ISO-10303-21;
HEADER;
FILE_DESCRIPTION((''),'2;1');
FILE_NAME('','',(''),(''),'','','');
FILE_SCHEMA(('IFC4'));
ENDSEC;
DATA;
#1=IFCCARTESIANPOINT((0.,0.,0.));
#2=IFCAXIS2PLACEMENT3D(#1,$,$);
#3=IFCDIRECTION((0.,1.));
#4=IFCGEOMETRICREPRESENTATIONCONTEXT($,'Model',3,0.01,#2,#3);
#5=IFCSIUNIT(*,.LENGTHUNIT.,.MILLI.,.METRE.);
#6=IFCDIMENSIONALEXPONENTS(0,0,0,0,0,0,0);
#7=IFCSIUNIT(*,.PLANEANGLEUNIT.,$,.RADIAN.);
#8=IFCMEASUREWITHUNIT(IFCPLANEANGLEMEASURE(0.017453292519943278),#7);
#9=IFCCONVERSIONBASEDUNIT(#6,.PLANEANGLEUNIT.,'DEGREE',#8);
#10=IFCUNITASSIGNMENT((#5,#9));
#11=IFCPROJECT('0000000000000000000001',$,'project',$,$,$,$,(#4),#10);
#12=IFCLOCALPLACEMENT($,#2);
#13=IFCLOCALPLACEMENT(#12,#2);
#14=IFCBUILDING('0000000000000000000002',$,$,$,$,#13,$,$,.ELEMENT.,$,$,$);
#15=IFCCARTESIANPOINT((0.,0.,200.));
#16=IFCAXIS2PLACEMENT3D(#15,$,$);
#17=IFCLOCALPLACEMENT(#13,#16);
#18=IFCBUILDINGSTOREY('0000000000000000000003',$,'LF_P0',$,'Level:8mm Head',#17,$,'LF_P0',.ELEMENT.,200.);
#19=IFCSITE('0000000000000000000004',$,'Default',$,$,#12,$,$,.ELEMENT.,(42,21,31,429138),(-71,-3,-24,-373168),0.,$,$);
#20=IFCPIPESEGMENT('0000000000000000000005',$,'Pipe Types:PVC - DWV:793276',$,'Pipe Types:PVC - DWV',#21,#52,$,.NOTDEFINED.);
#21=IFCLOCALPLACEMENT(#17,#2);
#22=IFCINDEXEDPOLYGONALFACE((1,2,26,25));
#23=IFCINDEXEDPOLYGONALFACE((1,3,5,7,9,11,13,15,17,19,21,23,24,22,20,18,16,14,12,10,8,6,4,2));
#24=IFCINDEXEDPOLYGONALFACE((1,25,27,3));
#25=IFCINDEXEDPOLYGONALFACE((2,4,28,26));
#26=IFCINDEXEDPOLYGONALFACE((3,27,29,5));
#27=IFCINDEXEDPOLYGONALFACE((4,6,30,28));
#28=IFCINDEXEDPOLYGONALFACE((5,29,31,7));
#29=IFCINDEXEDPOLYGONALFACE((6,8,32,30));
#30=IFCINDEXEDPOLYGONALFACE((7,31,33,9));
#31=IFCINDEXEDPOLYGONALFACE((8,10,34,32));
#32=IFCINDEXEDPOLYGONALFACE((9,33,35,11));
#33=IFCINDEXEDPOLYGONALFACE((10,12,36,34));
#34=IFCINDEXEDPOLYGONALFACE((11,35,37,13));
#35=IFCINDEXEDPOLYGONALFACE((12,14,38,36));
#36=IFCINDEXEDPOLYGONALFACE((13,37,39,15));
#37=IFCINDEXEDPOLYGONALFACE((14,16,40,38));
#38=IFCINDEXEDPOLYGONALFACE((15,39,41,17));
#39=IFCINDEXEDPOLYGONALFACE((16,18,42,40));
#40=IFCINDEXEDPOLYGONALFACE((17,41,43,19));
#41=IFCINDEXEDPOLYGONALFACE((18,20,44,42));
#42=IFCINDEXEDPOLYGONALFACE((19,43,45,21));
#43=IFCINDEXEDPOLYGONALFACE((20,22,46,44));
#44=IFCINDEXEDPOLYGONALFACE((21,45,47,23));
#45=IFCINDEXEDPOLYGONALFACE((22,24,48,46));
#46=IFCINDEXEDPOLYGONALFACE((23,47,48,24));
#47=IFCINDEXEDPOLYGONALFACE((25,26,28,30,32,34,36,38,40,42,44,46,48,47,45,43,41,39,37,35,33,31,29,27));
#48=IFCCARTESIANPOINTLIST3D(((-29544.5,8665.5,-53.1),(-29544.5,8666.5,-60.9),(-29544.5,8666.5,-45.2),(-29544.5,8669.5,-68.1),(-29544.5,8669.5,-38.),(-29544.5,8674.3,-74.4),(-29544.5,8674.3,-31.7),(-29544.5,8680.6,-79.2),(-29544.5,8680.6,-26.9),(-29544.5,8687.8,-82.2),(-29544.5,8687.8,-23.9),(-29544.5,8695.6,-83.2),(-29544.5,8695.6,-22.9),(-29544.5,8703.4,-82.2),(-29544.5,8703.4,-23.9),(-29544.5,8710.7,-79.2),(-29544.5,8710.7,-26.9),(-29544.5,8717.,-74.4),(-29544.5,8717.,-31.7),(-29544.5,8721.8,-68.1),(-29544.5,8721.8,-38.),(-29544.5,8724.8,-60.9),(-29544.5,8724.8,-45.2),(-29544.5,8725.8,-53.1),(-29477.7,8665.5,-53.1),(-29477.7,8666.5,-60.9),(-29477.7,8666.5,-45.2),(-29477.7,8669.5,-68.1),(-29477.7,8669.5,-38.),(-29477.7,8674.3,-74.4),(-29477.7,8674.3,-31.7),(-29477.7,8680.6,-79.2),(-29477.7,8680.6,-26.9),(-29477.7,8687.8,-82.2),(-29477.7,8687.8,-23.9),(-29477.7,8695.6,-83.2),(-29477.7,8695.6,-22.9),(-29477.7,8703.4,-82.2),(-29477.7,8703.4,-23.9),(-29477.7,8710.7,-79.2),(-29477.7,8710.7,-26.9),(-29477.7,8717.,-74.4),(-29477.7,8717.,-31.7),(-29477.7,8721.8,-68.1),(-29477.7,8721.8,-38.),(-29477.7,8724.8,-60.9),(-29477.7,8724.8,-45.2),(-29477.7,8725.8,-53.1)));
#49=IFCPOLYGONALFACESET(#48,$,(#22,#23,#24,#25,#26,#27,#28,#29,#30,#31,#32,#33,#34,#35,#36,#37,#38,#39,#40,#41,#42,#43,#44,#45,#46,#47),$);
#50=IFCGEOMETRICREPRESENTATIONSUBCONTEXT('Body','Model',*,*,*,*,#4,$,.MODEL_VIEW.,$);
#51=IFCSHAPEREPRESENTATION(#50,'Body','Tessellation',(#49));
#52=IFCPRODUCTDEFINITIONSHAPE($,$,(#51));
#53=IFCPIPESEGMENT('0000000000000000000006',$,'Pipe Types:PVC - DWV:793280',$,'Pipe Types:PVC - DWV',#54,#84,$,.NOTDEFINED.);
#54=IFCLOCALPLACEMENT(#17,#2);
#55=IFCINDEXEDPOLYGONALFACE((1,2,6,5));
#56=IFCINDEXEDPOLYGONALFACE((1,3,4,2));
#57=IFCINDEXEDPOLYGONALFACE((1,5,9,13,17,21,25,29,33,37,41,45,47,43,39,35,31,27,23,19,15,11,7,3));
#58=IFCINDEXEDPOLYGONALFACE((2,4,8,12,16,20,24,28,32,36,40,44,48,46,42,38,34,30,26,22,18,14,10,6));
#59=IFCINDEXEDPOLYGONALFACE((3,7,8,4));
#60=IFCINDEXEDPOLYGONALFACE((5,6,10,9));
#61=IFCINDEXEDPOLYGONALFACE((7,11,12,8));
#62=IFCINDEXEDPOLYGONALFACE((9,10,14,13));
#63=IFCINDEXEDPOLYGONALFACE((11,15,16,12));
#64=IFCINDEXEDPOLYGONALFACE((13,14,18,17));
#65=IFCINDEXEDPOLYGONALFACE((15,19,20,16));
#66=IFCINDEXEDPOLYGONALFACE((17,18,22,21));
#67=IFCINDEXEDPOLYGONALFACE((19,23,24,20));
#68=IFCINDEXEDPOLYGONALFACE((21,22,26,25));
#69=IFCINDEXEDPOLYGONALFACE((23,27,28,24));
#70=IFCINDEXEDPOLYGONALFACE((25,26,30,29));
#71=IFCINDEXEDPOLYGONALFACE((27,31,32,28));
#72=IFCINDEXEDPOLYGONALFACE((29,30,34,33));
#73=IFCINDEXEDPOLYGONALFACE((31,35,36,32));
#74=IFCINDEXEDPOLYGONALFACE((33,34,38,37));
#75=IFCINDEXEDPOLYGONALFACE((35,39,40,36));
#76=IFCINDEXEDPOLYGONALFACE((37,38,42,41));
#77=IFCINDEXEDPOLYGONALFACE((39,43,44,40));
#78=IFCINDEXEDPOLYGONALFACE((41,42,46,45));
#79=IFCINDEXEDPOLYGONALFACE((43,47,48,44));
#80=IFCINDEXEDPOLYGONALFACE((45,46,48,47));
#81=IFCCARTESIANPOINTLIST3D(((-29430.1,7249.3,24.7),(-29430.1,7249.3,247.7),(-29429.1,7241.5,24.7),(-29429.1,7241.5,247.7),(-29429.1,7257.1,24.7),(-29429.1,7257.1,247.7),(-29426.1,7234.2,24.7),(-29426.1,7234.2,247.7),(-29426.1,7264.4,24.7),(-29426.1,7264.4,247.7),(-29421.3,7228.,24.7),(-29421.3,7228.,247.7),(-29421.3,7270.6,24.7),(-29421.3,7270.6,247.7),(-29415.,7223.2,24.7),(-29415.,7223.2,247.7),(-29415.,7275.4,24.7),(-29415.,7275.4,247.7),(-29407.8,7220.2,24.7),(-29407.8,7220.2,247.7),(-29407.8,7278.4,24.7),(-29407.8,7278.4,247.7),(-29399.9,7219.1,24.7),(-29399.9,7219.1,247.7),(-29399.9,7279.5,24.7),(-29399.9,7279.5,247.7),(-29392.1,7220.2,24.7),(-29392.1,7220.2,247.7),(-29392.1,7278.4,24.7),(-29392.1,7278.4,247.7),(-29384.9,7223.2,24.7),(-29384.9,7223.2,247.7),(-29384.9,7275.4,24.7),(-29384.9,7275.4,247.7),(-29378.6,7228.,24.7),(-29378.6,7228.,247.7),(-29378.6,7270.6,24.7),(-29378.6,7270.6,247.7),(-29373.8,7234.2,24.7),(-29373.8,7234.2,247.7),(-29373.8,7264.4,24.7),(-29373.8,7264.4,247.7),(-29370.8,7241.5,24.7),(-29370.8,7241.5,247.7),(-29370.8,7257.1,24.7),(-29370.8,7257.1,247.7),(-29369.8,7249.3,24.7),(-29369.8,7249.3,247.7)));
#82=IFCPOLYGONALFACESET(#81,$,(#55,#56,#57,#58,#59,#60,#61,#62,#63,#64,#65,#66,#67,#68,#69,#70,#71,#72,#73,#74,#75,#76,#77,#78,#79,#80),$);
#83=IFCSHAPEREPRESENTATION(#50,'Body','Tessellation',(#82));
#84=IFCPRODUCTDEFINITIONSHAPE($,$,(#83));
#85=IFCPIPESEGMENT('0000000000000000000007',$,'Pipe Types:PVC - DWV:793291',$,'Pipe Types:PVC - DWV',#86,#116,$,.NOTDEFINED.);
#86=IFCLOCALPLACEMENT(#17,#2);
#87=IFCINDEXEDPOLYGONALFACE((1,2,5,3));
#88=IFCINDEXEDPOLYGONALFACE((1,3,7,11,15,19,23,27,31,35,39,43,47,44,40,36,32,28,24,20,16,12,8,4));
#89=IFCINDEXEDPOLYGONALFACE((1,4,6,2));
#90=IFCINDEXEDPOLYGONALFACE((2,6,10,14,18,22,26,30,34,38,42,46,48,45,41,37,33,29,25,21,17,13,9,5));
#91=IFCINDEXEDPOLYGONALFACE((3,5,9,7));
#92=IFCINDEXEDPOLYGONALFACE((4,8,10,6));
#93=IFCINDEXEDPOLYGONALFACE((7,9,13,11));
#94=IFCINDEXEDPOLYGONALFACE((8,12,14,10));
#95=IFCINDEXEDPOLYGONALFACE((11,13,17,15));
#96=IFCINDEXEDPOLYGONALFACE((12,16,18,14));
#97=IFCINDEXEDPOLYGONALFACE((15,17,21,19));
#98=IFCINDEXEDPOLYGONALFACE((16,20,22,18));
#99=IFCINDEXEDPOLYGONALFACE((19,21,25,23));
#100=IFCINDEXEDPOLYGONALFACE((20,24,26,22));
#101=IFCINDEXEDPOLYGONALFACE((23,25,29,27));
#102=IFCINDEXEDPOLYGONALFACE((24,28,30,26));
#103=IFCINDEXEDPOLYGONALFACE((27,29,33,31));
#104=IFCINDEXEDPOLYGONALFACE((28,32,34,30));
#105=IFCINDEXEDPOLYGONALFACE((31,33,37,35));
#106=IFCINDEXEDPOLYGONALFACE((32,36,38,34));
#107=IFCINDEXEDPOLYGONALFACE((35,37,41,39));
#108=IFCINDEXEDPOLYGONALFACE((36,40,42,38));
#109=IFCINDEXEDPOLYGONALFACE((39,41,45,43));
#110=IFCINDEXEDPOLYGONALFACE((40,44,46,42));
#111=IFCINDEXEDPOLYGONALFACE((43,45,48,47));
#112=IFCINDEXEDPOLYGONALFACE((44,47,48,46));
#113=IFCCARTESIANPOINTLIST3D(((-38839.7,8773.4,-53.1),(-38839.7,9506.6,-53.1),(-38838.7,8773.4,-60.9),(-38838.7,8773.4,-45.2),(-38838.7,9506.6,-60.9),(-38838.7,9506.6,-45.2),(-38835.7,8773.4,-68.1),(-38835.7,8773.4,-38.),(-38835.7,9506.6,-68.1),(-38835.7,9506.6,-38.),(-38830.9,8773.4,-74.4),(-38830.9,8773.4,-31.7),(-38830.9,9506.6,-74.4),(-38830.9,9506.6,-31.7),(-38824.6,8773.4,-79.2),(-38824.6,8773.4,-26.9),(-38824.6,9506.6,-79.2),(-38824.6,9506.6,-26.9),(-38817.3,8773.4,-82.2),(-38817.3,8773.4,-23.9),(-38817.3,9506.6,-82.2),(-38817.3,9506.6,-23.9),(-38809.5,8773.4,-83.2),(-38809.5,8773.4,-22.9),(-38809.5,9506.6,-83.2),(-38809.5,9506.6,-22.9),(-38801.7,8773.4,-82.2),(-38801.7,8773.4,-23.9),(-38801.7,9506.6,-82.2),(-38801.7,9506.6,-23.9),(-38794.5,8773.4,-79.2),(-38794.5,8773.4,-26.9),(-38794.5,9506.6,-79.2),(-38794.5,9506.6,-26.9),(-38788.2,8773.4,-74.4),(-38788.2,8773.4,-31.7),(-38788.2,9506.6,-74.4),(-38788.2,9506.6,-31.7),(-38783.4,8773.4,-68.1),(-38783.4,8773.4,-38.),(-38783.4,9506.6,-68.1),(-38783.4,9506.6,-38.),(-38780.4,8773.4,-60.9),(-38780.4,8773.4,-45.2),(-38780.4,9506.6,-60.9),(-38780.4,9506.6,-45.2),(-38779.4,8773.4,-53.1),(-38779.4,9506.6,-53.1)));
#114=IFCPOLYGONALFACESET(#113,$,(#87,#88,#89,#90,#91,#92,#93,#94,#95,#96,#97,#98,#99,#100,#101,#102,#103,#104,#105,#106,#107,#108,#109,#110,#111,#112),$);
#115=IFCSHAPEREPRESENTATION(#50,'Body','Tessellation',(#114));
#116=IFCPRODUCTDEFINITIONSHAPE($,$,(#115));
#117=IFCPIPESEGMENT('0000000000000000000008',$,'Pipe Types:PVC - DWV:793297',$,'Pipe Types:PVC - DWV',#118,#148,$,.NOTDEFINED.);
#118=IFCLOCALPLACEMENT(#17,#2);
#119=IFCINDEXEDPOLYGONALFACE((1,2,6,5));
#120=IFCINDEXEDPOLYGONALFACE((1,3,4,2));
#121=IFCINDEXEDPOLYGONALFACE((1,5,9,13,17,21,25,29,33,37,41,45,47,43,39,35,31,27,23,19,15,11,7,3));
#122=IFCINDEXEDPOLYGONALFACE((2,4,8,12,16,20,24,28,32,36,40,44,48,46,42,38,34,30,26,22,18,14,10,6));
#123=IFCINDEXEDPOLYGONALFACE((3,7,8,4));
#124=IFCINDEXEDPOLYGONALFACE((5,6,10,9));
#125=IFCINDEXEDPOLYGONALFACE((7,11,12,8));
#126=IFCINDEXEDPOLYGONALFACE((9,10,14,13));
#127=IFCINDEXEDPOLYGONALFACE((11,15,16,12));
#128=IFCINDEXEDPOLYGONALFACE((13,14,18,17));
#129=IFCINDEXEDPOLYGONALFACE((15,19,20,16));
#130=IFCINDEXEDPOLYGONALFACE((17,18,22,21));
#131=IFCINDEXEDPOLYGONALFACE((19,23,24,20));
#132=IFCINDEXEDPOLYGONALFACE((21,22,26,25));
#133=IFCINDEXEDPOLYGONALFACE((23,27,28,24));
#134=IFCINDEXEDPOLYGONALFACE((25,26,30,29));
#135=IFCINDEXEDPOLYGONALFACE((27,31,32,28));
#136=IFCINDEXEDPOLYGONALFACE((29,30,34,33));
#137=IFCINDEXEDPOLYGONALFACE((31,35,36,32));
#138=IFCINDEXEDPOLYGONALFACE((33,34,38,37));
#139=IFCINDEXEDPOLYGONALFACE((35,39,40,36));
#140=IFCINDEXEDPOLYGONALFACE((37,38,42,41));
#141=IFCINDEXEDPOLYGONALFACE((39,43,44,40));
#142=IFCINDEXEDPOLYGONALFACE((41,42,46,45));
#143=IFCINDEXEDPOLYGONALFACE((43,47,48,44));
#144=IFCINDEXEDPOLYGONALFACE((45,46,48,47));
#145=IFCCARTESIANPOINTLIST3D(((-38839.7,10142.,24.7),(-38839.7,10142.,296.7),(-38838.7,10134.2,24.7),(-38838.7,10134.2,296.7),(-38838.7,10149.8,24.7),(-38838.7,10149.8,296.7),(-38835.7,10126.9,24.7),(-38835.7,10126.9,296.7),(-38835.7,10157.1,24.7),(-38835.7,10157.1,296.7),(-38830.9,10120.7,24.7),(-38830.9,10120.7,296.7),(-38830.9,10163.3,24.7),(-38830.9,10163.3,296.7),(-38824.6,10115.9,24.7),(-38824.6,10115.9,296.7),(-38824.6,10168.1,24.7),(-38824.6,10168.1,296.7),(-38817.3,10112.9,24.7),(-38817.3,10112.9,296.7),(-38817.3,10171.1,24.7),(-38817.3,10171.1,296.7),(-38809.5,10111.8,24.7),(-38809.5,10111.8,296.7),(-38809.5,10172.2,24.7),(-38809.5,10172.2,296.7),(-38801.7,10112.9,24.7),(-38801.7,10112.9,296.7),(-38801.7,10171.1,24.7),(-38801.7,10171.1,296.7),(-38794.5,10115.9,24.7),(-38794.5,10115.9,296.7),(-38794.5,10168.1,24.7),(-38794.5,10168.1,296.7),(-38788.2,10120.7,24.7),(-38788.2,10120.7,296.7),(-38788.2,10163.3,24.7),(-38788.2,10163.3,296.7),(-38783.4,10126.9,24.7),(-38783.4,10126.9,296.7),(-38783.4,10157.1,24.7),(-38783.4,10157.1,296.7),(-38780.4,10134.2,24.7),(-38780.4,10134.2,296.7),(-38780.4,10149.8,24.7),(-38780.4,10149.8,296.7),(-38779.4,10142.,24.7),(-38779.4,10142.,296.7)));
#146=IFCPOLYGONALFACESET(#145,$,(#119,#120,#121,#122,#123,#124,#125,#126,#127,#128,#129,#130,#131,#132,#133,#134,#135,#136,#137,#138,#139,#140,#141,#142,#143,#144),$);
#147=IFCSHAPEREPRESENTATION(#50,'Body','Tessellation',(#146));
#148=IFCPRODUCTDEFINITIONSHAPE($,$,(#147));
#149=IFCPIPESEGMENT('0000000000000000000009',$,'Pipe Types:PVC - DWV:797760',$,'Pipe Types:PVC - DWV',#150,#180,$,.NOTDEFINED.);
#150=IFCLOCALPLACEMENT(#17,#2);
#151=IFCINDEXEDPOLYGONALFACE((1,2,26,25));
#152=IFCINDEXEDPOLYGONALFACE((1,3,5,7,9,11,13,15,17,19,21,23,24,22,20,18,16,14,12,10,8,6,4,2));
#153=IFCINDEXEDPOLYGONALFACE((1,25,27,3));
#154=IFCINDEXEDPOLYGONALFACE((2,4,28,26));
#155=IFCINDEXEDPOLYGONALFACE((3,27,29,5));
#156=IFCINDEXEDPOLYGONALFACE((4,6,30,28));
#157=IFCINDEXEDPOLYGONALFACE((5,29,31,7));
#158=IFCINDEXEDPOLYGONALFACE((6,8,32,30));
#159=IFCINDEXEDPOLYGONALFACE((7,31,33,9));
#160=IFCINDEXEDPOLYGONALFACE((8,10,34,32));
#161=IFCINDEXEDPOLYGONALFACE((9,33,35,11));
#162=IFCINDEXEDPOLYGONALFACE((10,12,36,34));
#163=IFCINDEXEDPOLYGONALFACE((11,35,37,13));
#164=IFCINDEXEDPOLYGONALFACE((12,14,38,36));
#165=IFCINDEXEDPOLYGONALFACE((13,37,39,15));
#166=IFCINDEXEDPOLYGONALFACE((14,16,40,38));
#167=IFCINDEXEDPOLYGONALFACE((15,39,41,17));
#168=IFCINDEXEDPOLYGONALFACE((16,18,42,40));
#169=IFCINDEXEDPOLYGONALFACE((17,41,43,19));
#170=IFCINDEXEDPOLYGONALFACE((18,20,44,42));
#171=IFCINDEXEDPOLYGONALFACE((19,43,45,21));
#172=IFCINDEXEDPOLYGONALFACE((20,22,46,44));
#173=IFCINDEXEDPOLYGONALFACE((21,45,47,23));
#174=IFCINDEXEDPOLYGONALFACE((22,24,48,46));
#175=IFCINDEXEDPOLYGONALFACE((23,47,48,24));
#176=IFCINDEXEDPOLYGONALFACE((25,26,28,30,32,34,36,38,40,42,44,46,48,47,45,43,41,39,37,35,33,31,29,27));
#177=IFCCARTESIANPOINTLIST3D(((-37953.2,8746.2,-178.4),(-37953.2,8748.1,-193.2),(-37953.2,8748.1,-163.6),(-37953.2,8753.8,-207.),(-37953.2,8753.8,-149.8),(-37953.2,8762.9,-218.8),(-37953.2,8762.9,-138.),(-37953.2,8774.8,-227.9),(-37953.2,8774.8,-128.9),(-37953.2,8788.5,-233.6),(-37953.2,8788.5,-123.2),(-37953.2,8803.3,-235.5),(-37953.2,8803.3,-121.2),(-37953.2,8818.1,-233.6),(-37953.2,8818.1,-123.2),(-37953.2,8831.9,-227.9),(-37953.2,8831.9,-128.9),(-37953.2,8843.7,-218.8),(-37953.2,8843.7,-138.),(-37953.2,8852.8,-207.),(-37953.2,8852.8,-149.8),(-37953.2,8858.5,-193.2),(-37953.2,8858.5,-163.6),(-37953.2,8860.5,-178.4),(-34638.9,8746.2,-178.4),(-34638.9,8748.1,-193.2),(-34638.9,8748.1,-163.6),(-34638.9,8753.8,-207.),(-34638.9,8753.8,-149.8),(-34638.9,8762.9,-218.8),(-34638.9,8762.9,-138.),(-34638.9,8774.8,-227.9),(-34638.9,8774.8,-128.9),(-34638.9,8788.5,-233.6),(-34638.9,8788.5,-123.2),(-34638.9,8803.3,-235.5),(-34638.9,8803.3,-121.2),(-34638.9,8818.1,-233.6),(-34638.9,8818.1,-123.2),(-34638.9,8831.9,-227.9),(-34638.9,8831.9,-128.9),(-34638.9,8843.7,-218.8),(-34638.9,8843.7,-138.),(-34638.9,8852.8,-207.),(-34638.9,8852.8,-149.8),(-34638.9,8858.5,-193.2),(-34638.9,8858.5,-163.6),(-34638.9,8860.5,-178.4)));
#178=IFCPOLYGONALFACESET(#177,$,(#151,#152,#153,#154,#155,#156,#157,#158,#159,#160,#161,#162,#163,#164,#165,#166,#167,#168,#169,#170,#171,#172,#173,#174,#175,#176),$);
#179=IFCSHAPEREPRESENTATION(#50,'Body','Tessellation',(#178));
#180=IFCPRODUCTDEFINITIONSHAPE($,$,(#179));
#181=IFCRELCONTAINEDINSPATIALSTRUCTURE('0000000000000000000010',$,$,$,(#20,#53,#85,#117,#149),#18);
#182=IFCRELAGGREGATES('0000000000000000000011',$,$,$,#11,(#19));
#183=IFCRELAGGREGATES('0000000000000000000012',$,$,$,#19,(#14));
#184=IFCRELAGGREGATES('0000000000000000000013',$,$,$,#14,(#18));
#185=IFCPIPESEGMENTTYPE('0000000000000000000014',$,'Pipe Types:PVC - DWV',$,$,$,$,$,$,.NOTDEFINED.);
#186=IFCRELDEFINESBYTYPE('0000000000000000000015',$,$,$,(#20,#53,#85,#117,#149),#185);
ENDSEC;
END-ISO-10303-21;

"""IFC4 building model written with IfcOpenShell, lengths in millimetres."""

from ifc_helpers import new_model, entity, si_unit, converted_unit, direction, frame, origin, place, context, subcontext, project, spatial, arc, indexed_curve, outline, extrude, type_object, element, save


model = new_model("IFC4")

# Units and contexts
model_context = context("Model", 3, precision=0.01, world=origin(), true_north=direction((0.0, 1.0)))
body_context = subcontext(model_context, "Body", "Model", "MODEL_VIEW")
ifc_project = project(units=[si_unit("LENGTHUNIT", "METRE", prefix="MILLI"), converted_unit("PLANEANGLEUNIT", "DEGREE", entity("IfcPlaneAngleMeasure", 0.017453292519943278), si_unit("PLANEANGLEUNIT", "RADIAN"), dimensions=[0, 0, 0, 0, 0, 0, 0])], contexts=[model_context])

# Site, building, storey
site_placement = place(None, origin())
site = spatial("IfcSite", under=ifc_project, at=site_placement, Name="Default", CompositionType="ELEMENT", RefLatitude=(42, 21, 31, 429138), RefLongitude=(-71, -3, -24, -373168), RefElevation=0.0)
building_placement = place(site_placement, origin())
building = spatial("IfcBuilding", under=site, at=building_placement, CompositionType="ELEMENT")
storey_placement = place(building_placement, frame((0.0, 0.0, 200.0)))
storey = spatial("IfcBuildingStorey", under=building, at=storey_placement, Name="LF_P0", ObjectType="Level:8mm Head", LongName="LF_P0", CompositionType="ELEMENT", Elevation=200.0)

# Pipe segments
pipe_segment_type_1 = type_object("IfcPipeSegmentType", Name="Pipe Types:PVC - DWV", PredefinedType="NOTDEFINED")
pipe_segment_1_placement = place(storey_placement, origin())
element("IfcPipeSegment", 1, at=pipe_segment_1_placement, inside=storey, type_object=pipe_segment_type_1, Name="Pipe Types:PVC - DWV:793276", ObjectType="Pipe Types:PVC - DWV", PredefinedType="NOTDEFINED", context=body_context, shape_type="SweptSolid", body=[
    extrude(outline(indexed_curve([(30.2, 0.0), (21.3, 21.3), (0.0, 30.2), (-21.3, 21.3), (-30.2, 0.0), (-21.3, -21.3), (0.0, -30.2), (21.3, -21.3)], segments=[arc(1, 2, 3), arc(3, 4, 5), arc(5, 6, 7), arc(7, 8, 1)], self_intersect=False)), frame((-29544.5, 8695.6, -53.1), z_axis=(1.0, 0.0, 0.0), x_axis=(0.0, 1.0, 0.0)), (0.0, 0.0, 1.0), 66.7),
])
pipe_segment_2_placement = place(storey_placement, origin())
element("IfcPipeSegment", 2, at=pipe_segment_2_placement, inside=storey, type_object=pipe_segment_type_1, Name="Pipe Types:PVC - DWV:793280", ObjectType="Pipe Types:PVC - DWV", PredefinedType="NOTDEFINED", context=body_context, shape_type="SweptSolid", body=[
    extrude(outline(indexed_curve([(30.2, 0.0), (21.3, 21.3), (0.0, 30.2), (-21.3, 21.3), (-30.2, 0.0), (-21.3, -21.3), (0.0, -30.2), (21.3, -21.3)], segments=[arc(1, 2, 3), arc(3, 4, 5), arc(5, 6, 7), arc(7, 8, 1)], self_intersect=False)), frame((-29399.9, 7249.3, 24.7)), (0.0, 0.0, 1.0), 223.0),
])
pipe_segment_3_placement = place(storey_placement, origin())
element("IfcPipeSegment", 3, at=pipe_segment_3_placement, inside=storey, type_object=pipe_segment_type_1, Name="Pipe Types:PVC - DWV:793291", ObjectType="Pipe Types:PVC - DWV", PredefinedType="NOTDEFINED", context=body_context, shape_type="SweptSolid", body=[
    extrude(outline(indexed_curve([(30.2, 0.0), (21.3, 21.3), (0.0, 30.2), (-21.3, 21.3), (-30.2, 0.0), (-21.3, -21.3), (0.0, -30.2), (21.3, -21.3)], segments=[arc(1, 2, 3), arc(3, 4, 5), arc(5, 6, 7), arc(7, 8, 1)], self_intersect=False)), frame((-38809.5, 8773.4, -53.1), z_axis=(0.0, 1.0, 0.0), x_axis=(-1.0, 0.0, 0.0)), (0.0, 0.0, 1.0), 733.2),
])
pipe_segment_4_placement = place(storey_placement, origin())
element("IfcPipeSegment", 4, at=pipe_segment_4_placement, inside=storey, type_object=pipe_segment_type_1, Name="Pipe Types:PVC - DWV:793297", ObjectType="Pipe Types:PVC - DWV", PredefinedType="NOTDEFINED", context=body_context, shape_type="SweptSolid", body=[
    extrude(outline(indexed_curve([(30.2, 0.0), (21.3, 21.3), (0.0, 30.2), (-21.3, 21.3), (-30.2, 0.0), (-21.3, -21.3), (0.0, -30.2), (21.3, -21.3)], segments=[arc(1, 2, 3), arc(3, 4, 5), arc(5, 6, 7), arc(7, 8, 1)], self_intersect=False)), frame((-38809.5, 10142.0, 24.7)), (0.0, 0.0, 1.0), 272.0),
])
pipe_segment_5_placement = place(storey_placement, origin())
element("IfcPipeSegment", 5, at=pipe_segment_5_placement, inside=storey, type_object=pipe_segment_type_1, Name="Pipe Types:PVC - DWV:797760", ObjectType="Pipe Types:PVC - DWV", PredefinedType="NOTDEFINED", context=body_context, shape_type="SweptSolid", body=[
    extrude(outline(indexed_curve([(57.2, 0.0), (40.4, 40.4), (0.0, 57.1), (-40.4, 40.4), (-57.1, 0.0), (-40.4, -40.4), (0.0, -57.2), (40.4, -40.4)], segments=[arc(1, 2, 3), arc(3, 4, 5), arc(5, 6, 7), arc(7, 8, 1)], self_intersect=False)), frame((-37953.2, 8803.3, -178.4), z_axis=(1.0, 0.0, 0.0), x_axis=(0.0, 1.0, 0.0)), (0.0, 0.0, 1.0), 3314.4),
])

save(model, "model.ifc")
